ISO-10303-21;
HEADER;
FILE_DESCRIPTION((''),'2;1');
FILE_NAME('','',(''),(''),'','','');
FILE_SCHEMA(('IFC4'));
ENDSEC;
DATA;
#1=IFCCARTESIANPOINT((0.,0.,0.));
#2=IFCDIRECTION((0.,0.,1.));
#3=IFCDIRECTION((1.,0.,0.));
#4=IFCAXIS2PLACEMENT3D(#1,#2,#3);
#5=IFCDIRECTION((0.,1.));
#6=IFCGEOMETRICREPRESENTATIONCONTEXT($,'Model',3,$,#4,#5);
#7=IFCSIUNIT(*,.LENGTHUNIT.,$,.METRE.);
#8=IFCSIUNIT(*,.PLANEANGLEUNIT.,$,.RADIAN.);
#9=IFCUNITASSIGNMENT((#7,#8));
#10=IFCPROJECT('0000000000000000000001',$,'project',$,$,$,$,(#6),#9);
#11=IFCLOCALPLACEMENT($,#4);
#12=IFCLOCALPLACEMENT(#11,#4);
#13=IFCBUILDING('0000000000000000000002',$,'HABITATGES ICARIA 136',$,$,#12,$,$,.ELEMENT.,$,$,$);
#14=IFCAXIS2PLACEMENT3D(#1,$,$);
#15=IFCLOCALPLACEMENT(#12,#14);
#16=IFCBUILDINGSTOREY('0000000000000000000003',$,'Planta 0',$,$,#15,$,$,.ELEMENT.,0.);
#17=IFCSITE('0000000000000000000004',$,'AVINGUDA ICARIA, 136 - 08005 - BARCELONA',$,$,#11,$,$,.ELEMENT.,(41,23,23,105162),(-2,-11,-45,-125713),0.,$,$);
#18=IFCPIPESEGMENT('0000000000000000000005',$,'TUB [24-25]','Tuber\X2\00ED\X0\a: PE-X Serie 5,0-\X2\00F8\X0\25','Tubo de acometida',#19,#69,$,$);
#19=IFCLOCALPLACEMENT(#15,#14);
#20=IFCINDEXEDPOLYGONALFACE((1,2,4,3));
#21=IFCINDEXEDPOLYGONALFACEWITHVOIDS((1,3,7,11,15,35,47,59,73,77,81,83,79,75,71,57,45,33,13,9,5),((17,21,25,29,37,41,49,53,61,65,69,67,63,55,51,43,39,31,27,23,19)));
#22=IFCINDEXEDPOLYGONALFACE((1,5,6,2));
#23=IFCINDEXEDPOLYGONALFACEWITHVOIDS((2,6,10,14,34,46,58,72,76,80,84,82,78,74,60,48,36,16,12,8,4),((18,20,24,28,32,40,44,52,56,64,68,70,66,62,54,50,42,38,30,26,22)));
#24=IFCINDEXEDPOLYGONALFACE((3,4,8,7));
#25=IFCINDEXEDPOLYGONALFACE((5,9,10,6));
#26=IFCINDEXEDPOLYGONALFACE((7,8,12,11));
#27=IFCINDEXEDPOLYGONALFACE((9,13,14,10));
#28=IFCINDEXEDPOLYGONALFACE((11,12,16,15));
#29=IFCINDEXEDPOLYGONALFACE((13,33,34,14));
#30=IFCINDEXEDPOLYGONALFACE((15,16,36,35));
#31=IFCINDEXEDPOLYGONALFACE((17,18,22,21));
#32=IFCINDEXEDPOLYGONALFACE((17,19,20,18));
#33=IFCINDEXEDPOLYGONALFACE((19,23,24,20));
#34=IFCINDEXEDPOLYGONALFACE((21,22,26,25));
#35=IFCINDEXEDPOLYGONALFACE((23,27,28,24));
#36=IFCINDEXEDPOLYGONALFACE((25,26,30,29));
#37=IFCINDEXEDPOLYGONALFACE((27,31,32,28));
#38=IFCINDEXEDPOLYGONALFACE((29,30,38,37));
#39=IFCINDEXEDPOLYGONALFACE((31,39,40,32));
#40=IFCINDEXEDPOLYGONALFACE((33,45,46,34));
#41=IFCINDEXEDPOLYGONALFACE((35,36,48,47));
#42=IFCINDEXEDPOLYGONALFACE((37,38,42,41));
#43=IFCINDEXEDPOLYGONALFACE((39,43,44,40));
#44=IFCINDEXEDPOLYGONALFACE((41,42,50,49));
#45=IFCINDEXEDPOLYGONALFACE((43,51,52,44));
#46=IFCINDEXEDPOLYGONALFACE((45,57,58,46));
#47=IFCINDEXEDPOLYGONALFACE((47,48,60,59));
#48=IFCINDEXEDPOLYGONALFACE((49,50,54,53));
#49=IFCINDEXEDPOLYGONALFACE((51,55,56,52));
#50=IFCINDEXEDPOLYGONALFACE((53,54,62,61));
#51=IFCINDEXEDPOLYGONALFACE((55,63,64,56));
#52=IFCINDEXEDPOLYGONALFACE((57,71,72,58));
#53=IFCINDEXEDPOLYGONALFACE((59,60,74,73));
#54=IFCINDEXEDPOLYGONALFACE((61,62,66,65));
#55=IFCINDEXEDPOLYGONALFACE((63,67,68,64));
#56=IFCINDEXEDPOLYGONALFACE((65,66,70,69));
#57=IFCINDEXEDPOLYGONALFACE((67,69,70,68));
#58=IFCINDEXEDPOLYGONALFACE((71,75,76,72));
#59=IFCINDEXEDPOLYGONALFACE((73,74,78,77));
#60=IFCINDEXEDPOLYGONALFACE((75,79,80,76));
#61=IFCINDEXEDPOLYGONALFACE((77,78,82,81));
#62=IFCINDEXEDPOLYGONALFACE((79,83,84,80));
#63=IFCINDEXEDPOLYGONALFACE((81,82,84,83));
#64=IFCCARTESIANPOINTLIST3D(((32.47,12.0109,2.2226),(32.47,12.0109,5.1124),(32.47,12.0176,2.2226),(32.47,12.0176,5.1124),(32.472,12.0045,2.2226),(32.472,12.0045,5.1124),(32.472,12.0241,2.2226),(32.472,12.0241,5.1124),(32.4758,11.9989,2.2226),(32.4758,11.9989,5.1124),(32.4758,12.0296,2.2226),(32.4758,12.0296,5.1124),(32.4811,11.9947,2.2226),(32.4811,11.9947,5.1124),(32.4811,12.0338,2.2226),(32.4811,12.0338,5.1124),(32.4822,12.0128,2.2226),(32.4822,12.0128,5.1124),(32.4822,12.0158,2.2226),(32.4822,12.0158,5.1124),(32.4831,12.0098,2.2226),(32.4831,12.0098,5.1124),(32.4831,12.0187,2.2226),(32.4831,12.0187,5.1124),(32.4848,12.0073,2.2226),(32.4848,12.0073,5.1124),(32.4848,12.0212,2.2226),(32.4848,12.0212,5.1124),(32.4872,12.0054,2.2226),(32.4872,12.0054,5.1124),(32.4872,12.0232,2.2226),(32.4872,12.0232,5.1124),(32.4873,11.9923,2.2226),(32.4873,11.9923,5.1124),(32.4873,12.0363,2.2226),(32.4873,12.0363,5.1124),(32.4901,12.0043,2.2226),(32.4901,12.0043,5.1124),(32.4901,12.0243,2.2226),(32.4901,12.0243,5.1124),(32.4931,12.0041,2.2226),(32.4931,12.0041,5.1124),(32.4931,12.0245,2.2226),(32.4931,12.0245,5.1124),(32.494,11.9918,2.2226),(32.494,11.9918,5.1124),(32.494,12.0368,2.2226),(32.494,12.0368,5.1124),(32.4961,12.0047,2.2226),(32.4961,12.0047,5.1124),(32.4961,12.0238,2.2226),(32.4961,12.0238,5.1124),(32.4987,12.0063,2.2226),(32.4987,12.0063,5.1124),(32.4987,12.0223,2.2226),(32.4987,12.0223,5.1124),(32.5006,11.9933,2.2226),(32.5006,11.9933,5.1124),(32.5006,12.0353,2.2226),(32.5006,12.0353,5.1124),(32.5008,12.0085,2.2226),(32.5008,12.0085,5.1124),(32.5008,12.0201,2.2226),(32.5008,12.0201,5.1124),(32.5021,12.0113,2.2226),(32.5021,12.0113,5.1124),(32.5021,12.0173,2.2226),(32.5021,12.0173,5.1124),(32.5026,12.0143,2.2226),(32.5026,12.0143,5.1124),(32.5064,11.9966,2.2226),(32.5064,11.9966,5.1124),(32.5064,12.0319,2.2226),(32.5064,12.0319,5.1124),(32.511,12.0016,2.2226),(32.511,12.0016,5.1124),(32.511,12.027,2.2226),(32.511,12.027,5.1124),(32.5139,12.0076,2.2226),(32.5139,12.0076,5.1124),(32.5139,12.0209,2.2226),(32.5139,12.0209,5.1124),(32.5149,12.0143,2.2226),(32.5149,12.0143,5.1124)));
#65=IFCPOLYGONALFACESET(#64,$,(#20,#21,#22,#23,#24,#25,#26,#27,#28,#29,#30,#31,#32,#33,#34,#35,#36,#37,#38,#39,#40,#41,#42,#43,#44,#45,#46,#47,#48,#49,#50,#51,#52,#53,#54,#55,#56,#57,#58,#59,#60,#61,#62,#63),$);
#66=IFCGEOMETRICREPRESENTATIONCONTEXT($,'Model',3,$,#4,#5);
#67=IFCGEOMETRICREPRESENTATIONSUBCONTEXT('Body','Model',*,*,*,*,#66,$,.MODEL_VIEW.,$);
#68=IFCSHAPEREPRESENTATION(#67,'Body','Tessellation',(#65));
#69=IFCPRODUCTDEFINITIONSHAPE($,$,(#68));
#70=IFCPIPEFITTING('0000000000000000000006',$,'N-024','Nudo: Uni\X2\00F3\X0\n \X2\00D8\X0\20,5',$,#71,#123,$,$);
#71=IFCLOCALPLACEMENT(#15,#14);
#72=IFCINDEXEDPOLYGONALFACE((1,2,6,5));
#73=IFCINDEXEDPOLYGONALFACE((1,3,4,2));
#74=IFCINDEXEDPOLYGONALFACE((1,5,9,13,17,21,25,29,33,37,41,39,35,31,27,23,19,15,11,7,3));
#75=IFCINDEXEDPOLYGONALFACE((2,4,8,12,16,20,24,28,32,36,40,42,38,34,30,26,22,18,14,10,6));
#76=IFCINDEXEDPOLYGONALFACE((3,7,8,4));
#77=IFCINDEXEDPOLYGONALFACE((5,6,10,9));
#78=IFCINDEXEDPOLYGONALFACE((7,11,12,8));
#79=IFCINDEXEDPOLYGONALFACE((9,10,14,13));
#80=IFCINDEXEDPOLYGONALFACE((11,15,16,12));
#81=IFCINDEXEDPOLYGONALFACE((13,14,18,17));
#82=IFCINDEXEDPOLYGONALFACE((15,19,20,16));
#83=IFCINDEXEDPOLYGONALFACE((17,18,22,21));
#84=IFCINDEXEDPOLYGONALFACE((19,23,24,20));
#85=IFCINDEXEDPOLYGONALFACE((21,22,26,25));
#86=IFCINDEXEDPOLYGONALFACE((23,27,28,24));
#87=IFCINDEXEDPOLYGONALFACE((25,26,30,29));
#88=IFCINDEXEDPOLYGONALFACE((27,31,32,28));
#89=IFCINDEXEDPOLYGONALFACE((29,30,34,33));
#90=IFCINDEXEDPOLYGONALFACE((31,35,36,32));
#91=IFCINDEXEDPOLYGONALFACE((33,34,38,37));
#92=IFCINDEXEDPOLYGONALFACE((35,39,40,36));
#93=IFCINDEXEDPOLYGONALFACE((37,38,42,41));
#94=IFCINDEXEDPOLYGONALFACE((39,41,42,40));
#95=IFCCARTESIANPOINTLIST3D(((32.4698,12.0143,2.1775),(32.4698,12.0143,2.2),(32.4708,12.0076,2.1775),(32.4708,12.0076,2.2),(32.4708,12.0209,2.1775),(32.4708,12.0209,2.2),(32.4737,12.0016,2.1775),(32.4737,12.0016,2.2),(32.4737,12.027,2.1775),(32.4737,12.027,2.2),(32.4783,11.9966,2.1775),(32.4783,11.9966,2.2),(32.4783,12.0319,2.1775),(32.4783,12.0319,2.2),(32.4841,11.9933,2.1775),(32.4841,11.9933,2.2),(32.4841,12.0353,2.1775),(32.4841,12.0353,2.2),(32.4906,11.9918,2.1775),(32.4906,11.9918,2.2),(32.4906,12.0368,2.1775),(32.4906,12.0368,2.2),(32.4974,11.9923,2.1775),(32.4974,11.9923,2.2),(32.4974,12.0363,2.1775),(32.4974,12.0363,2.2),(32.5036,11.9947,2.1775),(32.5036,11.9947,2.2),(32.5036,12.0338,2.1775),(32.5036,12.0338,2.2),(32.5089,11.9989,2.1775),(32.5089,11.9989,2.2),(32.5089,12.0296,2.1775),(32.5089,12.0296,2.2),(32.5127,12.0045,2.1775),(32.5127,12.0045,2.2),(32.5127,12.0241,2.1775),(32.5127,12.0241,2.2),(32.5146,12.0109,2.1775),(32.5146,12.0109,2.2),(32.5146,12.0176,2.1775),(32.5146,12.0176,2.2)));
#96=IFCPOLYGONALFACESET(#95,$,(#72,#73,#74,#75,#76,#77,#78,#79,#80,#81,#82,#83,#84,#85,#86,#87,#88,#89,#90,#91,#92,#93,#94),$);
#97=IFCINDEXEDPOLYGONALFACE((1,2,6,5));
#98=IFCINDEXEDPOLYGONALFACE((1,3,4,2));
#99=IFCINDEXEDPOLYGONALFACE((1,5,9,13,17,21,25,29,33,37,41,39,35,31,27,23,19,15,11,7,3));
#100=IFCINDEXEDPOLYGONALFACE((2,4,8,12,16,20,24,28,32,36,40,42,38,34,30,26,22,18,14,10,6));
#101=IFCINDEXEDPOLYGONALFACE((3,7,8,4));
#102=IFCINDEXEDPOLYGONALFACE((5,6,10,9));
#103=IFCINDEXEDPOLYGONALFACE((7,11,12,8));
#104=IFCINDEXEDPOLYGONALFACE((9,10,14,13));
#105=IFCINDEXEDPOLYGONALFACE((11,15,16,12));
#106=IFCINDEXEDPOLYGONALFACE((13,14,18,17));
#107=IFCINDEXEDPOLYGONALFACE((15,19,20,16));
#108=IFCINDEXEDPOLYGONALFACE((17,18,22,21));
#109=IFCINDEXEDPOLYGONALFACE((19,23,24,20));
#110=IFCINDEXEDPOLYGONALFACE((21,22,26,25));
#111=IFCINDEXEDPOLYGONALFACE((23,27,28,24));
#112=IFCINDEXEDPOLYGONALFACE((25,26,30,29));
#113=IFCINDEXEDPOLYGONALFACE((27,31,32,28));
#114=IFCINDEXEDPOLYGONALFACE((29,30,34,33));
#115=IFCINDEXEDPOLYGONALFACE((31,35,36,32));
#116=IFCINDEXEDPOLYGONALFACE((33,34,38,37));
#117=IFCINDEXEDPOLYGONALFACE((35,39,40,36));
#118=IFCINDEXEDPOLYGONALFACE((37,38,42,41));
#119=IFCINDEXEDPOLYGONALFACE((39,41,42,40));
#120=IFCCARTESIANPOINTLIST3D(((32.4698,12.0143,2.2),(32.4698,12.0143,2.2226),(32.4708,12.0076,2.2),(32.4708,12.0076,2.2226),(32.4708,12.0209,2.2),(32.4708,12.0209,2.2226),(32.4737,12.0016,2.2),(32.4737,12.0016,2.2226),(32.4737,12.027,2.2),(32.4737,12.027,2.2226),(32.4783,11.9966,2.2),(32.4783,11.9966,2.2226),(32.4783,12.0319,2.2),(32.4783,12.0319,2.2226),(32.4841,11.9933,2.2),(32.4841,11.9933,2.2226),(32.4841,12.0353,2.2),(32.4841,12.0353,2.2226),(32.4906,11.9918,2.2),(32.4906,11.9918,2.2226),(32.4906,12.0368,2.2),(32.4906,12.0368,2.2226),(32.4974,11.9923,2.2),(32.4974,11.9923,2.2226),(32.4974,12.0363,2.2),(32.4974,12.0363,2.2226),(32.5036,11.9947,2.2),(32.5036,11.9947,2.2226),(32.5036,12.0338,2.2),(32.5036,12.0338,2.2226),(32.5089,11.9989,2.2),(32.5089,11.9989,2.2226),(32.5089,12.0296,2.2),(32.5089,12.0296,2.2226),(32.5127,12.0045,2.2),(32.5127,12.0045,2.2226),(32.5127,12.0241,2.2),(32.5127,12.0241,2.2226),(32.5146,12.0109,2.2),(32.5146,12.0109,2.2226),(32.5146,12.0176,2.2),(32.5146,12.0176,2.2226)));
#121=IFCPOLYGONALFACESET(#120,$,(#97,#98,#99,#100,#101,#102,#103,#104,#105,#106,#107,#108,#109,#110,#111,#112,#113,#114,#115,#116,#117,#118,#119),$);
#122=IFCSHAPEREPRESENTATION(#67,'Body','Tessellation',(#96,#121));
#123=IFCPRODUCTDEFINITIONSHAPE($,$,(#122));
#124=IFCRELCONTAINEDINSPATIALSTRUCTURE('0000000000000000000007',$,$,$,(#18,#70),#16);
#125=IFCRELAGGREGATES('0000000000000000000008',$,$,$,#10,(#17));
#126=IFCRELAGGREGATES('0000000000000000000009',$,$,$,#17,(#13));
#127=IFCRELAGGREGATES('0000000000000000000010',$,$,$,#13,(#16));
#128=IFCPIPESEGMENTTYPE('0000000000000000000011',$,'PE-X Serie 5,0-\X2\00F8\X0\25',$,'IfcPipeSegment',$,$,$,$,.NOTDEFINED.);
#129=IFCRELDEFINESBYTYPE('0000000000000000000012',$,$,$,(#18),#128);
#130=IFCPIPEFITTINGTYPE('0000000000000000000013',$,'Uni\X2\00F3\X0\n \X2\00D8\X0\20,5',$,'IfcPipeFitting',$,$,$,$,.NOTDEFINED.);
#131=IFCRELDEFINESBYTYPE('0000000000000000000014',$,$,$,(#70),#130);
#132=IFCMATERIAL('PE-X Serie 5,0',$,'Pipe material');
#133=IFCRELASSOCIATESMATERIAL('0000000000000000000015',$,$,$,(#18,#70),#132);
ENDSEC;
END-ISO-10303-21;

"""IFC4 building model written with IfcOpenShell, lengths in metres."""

from ifc_helpers import new_model, si_unit, direction, frame, origin, origin_with_axes, origin_2d_with_axis, place, context, subcontext, project, spatial, circle, hollow_circle, extrude, source, transform, mapped, material, type_object, element, save


model = new_model("IFC4")

# Units and contexts
model_context_1 = context("Model", 3, world=origin_with_axes(), true_north=direction((0.0, 1.0)))
model_context_2 = context("Model", 3, world=origin_with_axes(), true_north=direction((0.0, 1.0)))
body_context_1 = subcontext(model_context_2, "Body", "Model", "MODEL_VIEW")
ifc_project = project(units=[si_unit("LENGTHUNIT", "METRE"), si_unit("PLANEANGLEUNIT", "RADIAN")], contexts=[model_context_1])

# Site, building, storey
site_placement = place(None, origin_with_axes())
site = spatial("IfcSite", under=ifc_project, at=site_placement, Name="AVINGUDA ICARIA, 136 - 08005 - BARCELONA", CompositionType="ELEMENT", RefLatitude=(41, 23, 23, 105162), RefLongitude=(-2, -11, -45, -125713), RefElevation=0.0)
building_placement = place(site_placement, origin_with_axes())
building = spatial("IfcBuilding", under=site, at=building_placement, Name="HABITATGES ICARIA 136", CompositionType="ELEMENT")
storey_placement = place(building_placement, origin())
storey = spatial("IfcBuildingStorey", under=building, at=storey_placement, Name="Planta 0", CompositionType="ELEMENT", Elevation=0.0)

# Pipe segment
ifc_material_1 = material(Name="PE-X Serie 5,0", Category="Pipe material")
pipe_segment_type = type_object("IfcPipeSegmentType", Name="PE-X Serie 5,0-ø25", ApplicableOccurrence="IfcPipeSegment", PredefinedType="NOTDEFINED")
placement_1 = place(None, origin_with_axes())
placement_2 = place(placement_1, origin_with_axes())
placement_3 = place(placement_2, origin())
pipe_segment_1_placement = place(placement_3, origin_with_axes())
element("IfcPipeSegment", 1, at=pipe_segment_1_placement, inside=storey, type_object=pipe_segment_type, material=ifc_material_1, Name="TUB [24-25]", Description="Tubería: PE-X Serie 5,0-ø25", ObjectType="Tubo de acometida", context=body_context_1, shape_type="SweptSolid", body=[
    extrude(hollow_circle(Radius=0.0226, WallThickness=0.0123, at=origin_2d_with_axis()), frame((32.4923, 12.0143, 2.2226), z_axis=(0.0, 0.0, 1.0), x_axis=(1.0, 0.0, 0.0)), (0.0, 0.0, 1.0), 2.8899),
])

# Pipe fitting
pipe_fitting_type = type_object("IfcPipeFittingType", Name="Unión Ø20,5", ApplicableOccurrence="IfcPipeFitting", PredefinedType="NOTDEFINED")
shared_shape = source(origin_with_axes(), body_context_1, "Body", "SweptSolid", [
    extrude(circle(Radius=0.0226, at=origin_2d_with_axis()), frame((0.0, 0.0, 0.0), z_axis=(0.0, 1.0, 0.0), x_axis=(-1.0, 0.0, 0.0)), (0.0, 0.0, 1.0), 0.0226),
    extrude(circle(Radius=0.0226, at=origin_2d_with_axis()), frame((0.0, -0.0226, 0.0), z_axis=(0.0, 1.0, 0.0), x_axis=(-1.0, 0.0, 0.0)), (0.0, 0.0, 1.0), 0.0226),
])
pipe_fitting_placement = place(placement_3, origin_with_axes())
element("IfcPipeFitting", 2, at=pipe_fitting_placement, inside=storey, type_object=pipe_fitting_type, material=ifc_material_1, Name="N-024", Description="Nudo: Unión Ø20,5", context=body_context_1, shape_type="MappedRepresentation", body=[
    mapped(shared_shape, transform((32.4923, 12.0143, 2.2), x_axis=(1.0, 0.0, 0.0), y_axis=(0.0, 0.0, -1.0), z_axis=(0.0, 1.0, 0.0), scale=1.0)),
])

save(model, "model.ifc")
